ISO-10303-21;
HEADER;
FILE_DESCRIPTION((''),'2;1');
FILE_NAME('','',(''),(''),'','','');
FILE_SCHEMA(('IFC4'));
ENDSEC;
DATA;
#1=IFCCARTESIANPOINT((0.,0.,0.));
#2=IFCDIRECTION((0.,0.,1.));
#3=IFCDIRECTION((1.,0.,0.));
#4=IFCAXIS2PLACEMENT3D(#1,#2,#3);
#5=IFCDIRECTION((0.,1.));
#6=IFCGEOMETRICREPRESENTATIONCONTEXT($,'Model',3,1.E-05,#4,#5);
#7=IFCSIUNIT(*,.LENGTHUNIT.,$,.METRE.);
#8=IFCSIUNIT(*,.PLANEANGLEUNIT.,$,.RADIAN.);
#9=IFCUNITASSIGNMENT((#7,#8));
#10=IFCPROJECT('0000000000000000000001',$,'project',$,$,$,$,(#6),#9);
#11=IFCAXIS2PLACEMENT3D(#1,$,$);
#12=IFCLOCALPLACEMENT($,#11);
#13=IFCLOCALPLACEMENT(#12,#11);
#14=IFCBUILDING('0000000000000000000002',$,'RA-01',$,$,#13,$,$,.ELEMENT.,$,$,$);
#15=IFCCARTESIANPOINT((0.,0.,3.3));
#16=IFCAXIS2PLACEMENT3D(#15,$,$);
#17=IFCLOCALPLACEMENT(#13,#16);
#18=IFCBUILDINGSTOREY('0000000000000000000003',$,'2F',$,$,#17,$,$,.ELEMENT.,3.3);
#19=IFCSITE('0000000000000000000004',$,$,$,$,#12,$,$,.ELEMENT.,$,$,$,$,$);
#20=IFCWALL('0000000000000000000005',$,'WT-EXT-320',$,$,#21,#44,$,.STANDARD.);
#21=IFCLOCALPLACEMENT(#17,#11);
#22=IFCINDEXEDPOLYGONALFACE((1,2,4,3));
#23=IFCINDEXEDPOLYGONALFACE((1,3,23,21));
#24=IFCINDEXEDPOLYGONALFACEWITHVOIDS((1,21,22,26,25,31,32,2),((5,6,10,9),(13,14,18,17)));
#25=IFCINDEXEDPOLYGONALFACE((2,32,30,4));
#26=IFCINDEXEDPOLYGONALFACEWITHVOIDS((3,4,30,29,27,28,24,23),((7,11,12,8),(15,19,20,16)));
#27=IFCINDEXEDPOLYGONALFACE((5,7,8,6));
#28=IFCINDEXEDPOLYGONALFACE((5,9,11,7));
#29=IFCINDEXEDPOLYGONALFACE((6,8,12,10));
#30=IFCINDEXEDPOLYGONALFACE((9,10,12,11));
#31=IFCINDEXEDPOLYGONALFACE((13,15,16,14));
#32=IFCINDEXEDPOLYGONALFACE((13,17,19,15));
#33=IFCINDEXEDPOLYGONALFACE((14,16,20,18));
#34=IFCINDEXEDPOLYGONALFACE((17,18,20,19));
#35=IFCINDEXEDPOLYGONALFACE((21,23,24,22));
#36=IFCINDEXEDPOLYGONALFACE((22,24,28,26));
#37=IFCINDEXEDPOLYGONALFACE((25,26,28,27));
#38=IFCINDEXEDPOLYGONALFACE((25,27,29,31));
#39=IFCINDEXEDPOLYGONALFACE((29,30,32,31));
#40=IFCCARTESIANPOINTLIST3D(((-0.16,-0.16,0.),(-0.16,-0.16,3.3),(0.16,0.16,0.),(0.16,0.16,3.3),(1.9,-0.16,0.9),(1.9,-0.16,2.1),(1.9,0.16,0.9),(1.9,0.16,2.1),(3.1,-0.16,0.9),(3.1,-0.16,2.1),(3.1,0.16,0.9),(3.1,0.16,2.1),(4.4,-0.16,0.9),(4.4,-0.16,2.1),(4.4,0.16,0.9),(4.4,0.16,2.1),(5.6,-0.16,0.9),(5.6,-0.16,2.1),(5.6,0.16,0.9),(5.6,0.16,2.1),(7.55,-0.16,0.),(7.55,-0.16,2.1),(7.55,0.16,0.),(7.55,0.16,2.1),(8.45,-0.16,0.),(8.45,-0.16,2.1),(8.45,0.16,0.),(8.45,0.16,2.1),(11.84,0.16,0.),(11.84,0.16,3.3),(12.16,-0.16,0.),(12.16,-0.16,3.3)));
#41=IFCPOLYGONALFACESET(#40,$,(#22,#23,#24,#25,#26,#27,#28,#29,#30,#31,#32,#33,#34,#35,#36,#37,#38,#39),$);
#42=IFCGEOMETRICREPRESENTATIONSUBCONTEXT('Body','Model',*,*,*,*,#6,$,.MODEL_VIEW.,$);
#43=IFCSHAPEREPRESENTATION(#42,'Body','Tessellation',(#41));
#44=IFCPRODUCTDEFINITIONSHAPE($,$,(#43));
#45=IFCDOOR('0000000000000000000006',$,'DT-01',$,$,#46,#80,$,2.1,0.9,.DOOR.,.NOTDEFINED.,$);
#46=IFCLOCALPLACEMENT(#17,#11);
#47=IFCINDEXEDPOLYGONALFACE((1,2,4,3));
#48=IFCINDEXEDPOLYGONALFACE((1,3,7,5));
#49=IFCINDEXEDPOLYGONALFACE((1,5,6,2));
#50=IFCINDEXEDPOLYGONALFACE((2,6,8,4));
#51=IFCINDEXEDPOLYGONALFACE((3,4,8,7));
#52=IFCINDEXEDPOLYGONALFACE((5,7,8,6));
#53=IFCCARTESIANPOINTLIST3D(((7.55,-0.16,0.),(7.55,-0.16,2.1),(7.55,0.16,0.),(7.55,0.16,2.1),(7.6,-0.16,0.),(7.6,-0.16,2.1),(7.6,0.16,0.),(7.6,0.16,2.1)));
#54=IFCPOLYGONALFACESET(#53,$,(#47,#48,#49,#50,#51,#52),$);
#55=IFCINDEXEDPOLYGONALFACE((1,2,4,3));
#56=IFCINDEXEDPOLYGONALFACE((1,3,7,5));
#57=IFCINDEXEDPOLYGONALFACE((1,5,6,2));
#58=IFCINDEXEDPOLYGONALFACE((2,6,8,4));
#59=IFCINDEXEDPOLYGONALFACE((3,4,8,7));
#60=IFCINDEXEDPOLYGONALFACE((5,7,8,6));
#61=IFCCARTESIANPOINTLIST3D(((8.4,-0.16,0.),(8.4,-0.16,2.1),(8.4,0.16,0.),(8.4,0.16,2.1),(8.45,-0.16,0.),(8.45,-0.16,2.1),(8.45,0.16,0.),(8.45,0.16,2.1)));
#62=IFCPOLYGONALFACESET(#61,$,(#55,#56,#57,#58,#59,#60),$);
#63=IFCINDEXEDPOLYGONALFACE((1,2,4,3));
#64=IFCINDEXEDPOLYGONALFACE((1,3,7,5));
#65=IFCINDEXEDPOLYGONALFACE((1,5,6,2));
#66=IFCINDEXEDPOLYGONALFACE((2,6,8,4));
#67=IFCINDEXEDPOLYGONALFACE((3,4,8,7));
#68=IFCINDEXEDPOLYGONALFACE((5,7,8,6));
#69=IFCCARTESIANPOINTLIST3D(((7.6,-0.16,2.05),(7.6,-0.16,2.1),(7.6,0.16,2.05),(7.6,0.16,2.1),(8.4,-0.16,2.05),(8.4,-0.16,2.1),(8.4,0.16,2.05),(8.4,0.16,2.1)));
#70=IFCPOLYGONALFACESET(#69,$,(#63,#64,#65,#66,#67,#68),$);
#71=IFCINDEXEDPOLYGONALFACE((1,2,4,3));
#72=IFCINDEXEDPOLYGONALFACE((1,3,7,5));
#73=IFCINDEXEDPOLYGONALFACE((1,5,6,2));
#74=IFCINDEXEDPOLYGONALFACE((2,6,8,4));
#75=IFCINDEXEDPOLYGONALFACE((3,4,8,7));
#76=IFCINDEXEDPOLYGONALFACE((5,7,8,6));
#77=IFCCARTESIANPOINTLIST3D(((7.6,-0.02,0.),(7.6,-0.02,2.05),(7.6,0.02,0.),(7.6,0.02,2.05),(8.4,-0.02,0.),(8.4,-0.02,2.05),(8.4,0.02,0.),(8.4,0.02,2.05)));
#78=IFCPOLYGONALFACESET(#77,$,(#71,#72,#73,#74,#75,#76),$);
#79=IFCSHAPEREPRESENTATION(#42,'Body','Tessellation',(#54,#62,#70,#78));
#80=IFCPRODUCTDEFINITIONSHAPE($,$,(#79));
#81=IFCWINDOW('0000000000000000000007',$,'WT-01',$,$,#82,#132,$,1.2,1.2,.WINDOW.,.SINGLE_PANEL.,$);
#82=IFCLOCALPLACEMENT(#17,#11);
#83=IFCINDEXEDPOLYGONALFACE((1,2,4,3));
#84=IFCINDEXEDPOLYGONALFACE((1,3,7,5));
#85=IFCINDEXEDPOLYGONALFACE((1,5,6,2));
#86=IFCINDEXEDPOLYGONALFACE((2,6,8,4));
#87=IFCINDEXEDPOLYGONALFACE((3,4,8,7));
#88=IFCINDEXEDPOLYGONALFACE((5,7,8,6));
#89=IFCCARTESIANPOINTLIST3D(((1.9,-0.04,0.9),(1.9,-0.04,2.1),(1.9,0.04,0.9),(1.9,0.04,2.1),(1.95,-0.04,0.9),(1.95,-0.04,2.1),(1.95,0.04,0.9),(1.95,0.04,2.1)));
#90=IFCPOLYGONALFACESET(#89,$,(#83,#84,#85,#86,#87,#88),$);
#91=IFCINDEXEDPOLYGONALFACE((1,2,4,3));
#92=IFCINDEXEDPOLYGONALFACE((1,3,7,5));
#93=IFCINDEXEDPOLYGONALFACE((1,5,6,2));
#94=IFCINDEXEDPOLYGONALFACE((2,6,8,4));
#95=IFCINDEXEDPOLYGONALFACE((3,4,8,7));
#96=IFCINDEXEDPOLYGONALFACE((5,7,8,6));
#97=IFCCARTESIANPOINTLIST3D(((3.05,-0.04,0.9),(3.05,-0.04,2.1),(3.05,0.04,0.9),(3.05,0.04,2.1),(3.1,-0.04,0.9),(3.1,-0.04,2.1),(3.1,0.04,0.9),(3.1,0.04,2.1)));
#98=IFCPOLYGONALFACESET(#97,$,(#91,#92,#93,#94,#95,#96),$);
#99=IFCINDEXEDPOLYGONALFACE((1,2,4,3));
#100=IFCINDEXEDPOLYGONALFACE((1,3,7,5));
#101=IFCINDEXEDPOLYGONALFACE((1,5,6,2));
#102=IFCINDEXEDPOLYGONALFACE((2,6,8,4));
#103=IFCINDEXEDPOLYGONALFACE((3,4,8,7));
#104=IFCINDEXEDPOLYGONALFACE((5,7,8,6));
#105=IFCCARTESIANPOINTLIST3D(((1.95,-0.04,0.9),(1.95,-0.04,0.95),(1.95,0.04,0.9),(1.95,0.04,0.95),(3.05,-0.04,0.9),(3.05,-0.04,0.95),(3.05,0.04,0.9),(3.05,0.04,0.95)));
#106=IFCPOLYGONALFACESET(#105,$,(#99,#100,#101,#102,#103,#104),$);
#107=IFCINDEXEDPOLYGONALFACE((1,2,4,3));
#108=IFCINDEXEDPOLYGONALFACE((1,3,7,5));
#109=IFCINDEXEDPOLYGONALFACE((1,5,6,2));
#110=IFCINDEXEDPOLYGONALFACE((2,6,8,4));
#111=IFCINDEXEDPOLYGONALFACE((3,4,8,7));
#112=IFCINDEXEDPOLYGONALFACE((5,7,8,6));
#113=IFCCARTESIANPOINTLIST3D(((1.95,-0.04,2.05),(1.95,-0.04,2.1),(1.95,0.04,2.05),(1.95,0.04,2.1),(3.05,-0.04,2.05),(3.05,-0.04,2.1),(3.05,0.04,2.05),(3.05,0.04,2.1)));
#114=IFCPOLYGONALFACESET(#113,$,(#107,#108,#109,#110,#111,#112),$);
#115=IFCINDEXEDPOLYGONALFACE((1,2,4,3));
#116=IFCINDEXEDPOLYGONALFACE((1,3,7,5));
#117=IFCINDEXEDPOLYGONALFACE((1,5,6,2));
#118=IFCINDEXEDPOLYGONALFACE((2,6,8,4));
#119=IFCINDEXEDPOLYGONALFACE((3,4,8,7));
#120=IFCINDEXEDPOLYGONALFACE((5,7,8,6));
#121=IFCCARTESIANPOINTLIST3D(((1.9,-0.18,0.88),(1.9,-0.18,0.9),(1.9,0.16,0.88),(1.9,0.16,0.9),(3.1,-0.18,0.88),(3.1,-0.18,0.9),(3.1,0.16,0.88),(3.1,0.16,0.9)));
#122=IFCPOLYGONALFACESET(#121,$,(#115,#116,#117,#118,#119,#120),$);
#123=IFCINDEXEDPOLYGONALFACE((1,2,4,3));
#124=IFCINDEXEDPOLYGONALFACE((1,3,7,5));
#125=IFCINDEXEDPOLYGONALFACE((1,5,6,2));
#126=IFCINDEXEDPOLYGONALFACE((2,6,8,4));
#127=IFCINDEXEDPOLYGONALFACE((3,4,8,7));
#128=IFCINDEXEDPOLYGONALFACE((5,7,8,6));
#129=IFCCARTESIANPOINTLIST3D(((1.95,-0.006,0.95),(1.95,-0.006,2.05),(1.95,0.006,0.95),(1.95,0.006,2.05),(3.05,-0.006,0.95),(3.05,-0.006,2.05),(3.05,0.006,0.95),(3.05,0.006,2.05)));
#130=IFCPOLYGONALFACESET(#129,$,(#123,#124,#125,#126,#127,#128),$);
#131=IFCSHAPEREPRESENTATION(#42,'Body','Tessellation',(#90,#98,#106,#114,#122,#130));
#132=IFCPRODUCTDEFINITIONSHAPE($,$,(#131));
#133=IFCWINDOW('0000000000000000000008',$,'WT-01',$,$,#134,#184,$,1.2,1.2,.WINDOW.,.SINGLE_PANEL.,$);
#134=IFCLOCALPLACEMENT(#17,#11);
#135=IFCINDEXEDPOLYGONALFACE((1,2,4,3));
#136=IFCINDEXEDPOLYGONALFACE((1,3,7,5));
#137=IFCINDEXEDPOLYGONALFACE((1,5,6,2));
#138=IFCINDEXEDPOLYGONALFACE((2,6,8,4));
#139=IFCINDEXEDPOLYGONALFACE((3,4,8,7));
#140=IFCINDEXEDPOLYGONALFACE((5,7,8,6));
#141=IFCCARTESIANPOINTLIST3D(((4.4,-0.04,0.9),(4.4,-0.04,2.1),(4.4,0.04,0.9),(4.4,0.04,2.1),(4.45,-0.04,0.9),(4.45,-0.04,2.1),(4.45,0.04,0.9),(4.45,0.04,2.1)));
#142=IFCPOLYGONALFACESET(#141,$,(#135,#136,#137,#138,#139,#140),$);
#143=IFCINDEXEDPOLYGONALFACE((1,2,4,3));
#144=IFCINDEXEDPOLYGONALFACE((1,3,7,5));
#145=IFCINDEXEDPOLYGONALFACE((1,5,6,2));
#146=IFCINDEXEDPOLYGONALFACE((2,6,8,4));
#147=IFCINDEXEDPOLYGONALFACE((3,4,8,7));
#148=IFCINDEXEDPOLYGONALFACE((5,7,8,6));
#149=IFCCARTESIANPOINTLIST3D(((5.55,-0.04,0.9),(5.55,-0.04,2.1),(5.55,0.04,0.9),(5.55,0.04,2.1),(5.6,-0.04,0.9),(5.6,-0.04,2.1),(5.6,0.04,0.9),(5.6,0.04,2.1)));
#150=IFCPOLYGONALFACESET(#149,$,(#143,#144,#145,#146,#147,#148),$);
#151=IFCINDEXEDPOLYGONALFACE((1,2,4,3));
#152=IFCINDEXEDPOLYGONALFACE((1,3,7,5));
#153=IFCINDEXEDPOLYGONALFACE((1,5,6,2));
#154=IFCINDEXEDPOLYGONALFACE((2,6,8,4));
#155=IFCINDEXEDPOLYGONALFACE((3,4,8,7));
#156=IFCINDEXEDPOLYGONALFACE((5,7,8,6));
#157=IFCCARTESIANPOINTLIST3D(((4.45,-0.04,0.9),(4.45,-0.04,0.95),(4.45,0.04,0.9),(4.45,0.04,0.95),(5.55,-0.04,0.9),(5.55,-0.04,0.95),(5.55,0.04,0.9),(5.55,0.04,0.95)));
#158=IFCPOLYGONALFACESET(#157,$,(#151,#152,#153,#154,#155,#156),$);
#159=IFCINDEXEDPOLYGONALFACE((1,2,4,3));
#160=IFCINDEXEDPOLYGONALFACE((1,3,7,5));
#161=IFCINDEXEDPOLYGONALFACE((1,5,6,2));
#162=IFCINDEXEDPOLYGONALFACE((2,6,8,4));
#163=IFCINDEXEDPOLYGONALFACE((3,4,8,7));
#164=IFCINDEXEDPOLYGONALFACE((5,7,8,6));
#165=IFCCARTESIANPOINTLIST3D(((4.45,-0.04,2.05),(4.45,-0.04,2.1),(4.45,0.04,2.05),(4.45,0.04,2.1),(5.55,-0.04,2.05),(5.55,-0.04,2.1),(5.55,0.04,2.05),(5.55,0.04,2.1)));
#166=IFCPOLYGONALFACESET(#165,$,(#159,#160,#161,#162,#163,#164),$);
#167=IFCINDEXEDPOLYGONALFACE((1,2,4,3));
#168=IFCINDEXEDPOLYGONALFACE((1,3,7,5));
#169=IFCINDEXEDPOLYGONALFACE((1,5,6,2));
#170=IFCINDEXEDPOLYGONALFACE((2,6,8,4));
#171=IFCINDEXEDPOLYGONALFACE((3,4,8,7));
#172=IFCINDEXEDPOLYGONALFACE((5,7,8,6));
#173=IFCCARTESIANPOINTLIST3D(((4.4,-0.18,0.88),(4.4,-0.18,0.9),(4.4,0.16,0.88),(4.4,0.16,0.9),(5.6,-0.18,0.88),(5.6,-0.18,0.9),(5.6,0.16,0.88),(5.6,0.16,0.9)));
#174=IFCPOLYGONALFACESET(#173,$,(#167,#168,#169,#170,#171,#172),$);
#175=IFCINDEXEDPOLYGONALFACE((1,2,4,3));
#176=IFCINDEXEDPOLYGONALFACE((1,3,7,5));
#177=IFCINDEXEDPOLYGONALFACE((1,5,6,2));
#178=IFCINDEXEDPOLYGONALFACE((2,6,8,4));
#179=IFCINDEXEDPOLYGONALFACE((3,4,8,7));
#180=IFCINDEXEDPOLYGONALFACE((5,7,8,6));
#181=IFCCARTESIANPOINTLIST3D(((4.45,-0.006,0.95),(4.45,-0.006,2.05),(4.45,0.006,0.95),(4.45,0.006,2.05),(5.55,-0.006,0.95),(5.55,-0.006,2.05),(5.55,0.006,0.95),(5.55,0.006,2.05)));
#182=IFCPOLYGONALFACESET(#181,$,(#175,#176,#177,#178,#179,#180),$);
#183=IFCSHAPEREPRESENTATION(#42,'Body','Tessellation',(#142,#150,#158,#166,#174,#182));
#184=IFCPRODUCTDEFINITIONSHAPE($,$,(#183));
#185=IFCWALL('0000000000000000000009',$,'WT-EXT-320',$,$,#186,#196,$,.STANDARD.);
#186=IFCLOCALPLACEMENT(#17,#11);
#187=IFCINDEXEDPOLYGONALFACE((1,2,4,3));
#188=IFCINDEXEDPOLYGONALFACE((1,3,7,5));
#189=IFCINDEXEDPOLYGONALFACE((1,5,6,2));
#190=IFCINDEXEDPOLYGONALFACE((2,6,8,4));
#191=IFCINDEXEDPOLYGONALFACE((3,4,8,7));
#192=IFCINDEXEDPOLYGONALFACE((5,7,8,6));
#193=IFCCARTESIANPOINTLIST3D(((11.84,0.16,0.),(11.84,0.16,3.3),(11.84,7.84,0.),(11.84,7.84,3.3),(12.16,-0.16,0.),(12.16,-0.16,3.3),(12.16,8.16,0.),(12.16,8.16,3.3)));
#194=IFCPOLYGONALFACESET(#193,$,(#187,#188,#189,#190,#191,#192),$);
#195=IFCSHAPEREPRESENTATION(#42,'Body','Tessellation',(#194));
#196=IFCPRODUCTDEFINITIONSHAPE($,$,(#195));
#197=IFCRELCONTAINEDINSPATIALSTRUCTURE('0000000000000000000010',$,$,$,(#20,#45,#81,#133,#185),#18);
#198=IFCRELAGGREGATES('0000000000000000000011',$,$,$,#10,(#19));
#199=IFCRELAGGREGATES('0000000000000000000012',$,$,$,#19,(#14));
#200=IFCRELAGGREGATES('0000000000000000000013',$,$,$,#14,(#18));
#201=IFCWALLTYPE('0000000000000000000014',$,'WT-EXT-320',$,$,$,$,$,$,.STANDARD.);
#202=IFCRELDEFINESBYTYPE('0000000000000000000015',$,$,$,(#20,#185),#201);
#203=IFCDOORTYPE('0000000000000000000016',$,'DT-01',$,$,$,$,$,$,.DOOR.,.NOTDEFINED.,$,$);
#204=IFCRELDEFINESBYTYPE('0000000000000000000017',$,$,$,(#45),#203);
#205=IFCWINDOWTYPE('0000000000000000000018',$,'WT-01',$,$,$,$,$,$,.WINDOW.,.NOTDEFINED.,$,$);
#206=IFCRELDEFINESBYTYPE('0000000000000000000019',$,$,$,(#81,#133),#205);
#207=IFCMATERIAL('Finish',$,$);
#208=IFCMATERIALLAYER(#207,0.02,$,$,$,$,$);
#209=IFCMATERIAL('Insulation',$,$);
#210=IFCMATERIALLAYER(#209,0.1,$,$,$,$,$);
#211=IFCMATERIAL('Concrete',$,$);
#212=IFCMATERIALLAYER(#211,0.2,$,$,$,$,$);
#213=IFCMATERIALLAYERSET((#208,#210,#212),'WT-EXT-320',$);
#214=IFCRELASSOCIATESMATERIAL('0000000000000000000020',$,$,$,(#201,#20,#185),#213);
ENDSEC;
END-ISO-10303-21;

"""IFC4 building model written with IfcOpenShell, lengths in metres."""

from ifc_helpers import new_model, si_unit, direction, frame, frame_2d, origin, origin_with_axes, place, context, subcontext, project, spatial, polyline, rectangle, outline, extrude, material, layer, layer_set, layer_usage, type_object, element, fill, save


model = new_model("IFC4")

# Units and contexts
model_context = context("Model", 3, precision=1e-05, world=origin_with_axes(), true_north=direction((0.0, 1.0)))
body_context = subcontext(model_context, "Body", "Model", "MODEL_VIEW")
ifc_project = project(units=[si_unit("LENGTHUNIT", "METRE"), si_unit("PLANEANGLEUNIT", "RADIAN")], contexts=[model_context])

# Site, building, storey
site_placement = place(None, origin())
site = spatial("IfcSite", under=ifc_project, at=site_placement, CompositionType="ELEMENT")
building_placement = place(site_placement, origin())
building = spatial("IfcBuilding", under=site, at=building_placement, Name="RA-01", CompositionType="ELEMENT")
storey_placement = place(building_placement, frame((0.0, 0.0, 3.3)))
storey = spatial("IfcBuildingStorey", under=building, at=storey_placement, Name="2F", CompositionType="ELEMENT", Elevation=3.3)

# Shared definitions
ifc_material_1 = material(Name="Concrete")

# Wall, openings, door, windows
ifc_material_2 = material(Name="Finish")
ifc_layer_1 = layer(ifc_material_2, 0.02)
ifc_material_3 = material(Name="Insulation")
ifc_layer_2 = layer(ifc_material_3, 0.1)
ifc_layer_3 = layer(ifc_material_1, 0.2)
ifc_layer_set_1 = layer_set([ifc_layer_1, ifc_layer_2, ifc_layer_3], Name="WT-EXT-320")
ifc_layer_usage_1 = layer_usage(ifc_layer_set_1, "AXIS2", "NEGATIVE", 0.16)
wall_type_1 = type_object("IfcWallType", Name="WT-EXT-320", PredefinedType="STANDARD", material=ifc_layer_set_1)
wall_1_placement = place(storey_placement, origin())
wall_1 = element("IfcWall", 1, at=wall_1_placement, inside=storey, type_object=wall_type_1, material=ifc_layer_usage_1, Name="WT-EXT-320", PredefinedType="STANDARD", context=body_context, shape_type="SweptSolid", body=[
    extrude(outline(polyline([(-0.16, -0.16), (12.16, -0.16), (11.84, 0.16), (0.16, 0.16), (-0.16, -0.16)])), origin(), (0.0, 0.0, 1.0), 3.3),
])
opening_1_placement = place(wall_1_placement, frame((7.55, 0.0, 0.0)))
opening_1 = element("IfcOpeningElement", 2, at=opening_1_placement, cuts=wall_1, PredefinedType="OPENING", context=body_context, shape_type="SweptSolid", body=[
    extrude(rectangle(XDim=0.9, YDim=0.42, at=frame_2d((0.45, 0.0))), origin(), (0.0, 0.0, 1.0), 2.1),
])
opening_2_placement = place(wall_1_placement, frame((1.9, 0.0, 0.9)))
opening_2 = element("IfcOpeningElement", 3, at=opening_2_placement, cuts=wall_1, PredefinedType="OPENING", context=body_context, shape_type="SweptSolid", body=[
    extrude(rectangle(XDim=1.2, YDim=0.42, at=frame_2d((0.6, 0.0))), origin(), (0.0, 0.0, 1.0), 1.2),
])
opening_3_placement = place(wall_1_placement, frame((4.4, 0.0, 0.9)))
opening_3 = element("IfcOpeningElement", 4, at=opening_3_placement, cuts=wall_1, PredefinedType="OPENING", context=body_context, shape_type="SweptSolid", body=[
    extrude(rectangle(XDim=1.2, YDim=0.42, at=frame_2d((0.6, 0.0))), origin(), (0.0, 0.0, 1.0), 1.2),
])
door_type_1 = type_object("IfcDoorType", Name="DT-01", OperationType="NOTDEFINED", PredefinedType="DOOR")
door_1_placement = place(opening_1_placement, origin())
door_1 = element("IfcDoor", 5, at=door_1_placement, inside=storey, type_object=door_type_1, Name="DT-01", OperationType="NOTDEFINED", OverallHeight=2.1, OverallWidth=0.9, PredefinedType="DOOR", context=body_context, shape_type="SweptSolid", body=[
    extrude(outline(polyline([(0.0, -0.16), (0.05, -0.16), (0.05, 0.16), (0.0, 0.16), (0.0, -0.16)])), origin(), (0.0, 0.0, 1.0), 2.1),
    extrude(outline(polyline([(0.85, -0.16), (0.9, -0.16), (0.9, 0.16), (0.85, 0.16), (0.85, -0.16)])), origin(), (0.0, 0.0, 1.0), 2.1),
    extrude(outline(polyline([(0.05, -0.16), (0.85, -0.16), (0.85, 0.16), (0.05, 0.16), (0.05, -0.16)])), frame((0.0, 0.0, 2.05)), (0.0, 0.0, 1.0), 0.05),
    extrude(outline(polyline([(0.05, -0.02), (0.85, -0.02), (0.85, 0.02), (0.05, 0.02), (0.05, -0.02)])), origin(), (0.0, 0.0, 1.0), 2.05),
])
fill(opening_1, door_1)
window_type_1 = type_object("IfcWindowType", Name="WT-01", PartitioningType="NOTDEFINED", PredefinedType="WINDOW")
window_1_placement = place(opening_2_placement, origin())
window_1 = element("IfcWindow", 6, at=window_1_placement, inside=storey, type_object=window_type_1, Name="WT-01", OverallHeight=1.2, OverallWidth=1.2, PartitioningType="SINGLE_PANEL", PredefinedType="WINDOW", context=body_context, shape_type="SweptSolid", body=[
    extrude(outline(polyline([(0.0, -0.04), (0.05, -0.04), (0.05, 0.04), (0.0, 0.04), (0.0, -0.04)])), origin(), (0.0, 0.0, 1.0), 1.2),
    extrude(outline(polyline([(1.15, -0.04), (1.2, -0.04), (1.2, 0.04), (1.15, 0.04), (1.15, -0.04)])), origin(), (0.0, 0.0, 1.0), 1.2),
    extrude(outline(polyline([(0.05, -0.04), (1.15, -0.04), (1.15, 0.04), (0.05, 0.04), (0.05, -0.04)])), origin(), (0.0, 0.0, 1.0), 0.05),
    extrude(outline(polyline([(0.05, -0.04), (1.15, -0.04), (1.15, 0.04), (0.05, 0.04), (0.05, -0.04)])), frame((0.0, 0.0, 1.15)), (0.0, 0.0, 1.0), 0.05),
    extrude(outline(polyline([(0.0, -0.18), (1.2, -0.18), (1.2, 0.16), (0.0, 0.16), (0.0, -0.18)])), frame((0.0, 0.0, -0.02)), (0.0, 0.0, 1.0), 0.02),
    extrude(outline(polyline([(0.05, -0.006), (1.15, -0.006), (1.15, 0.006), (0.05, 0.006), (0.05, -0.006)])), frame((0.0, 0.0, 0.05)), (0.0, 0.0, 1.0), 1.1),
])
fill(opening_2, window_1)
window_2_placement = place(opening_3_placement, origin())
window_2 = element("IfcWindow", 7, at=window_2_placement, inside=storey, type_object=window_type_1, Name="WT-01", OverallHeight=1.2, OverallWidth=1.2, PartitioningType="SINGLE_PANEL", PredefinedType="WINDOW", context=body_context, shape_type="SweptSolid", body=[
    extrude(outline(polyline([(0.0, -0.04), (0.05, -0.04), (0.05, 0.04), (0.0, 0.04), (0.0, -0.04)])), origin(), (0.0, 0.0, 1.0), 1.2),
    extrude(outline(polyline([(1.15, -0.04), (1.2, -0.04), (1.2, 0.04), (1.15, 0.04), (1.15, -0.04)])), origin(), (0.0, 0.0, 1.0), 1.2),
    extrude(outline(polyline([(0.05, -0.04), (1.15, -0.04), (1.15, 0.04), (0.05, 0.04), (0.05, -0.04)])), origin(), (0.0, 0.0, 1.0), 0.05),
    extrude(outline(polyline([(0.05, -0.04), (1.15, -0.04), (1.15, 0.04), (0.05, 0.04), (0.05, -0.04)])), frame((0.0, 0.0, 1.15)), (0.0, 0.0, 1.0), 0.05),
    extrude(outline(polyline([(0.0, -0.18), (1.2, -0.18), (1.2, 0.16), (0.0, 0.16), (0.0, -0.18)])), frame((0.0, 0.0, -0.02)), (0.0, 0.0, 1.0), 0.02),
    extrude(outline(polyline([(0.05, -0.006), (1.15, -0.006), (1.15, 0.006), (0.05, 0.006), (0.05, -0.006)])), frame((0.0, 0.0, 0.05)), (0.0, 0.0, 1.0), 1.1),
])
fill(opening_3, window_2)

# Wall
wall_2_placement = place(storey_placement, frame((12.0, 0.0, 0.0), z_axis=(0.0, 0.0, 1.0), x_axis=(0.0, 1.0, 0.0)))
element("IfcWall", 8, at=wall_2_placement, inside=storey, type_object=wall_type_1, material=ifc_layer_usage_1, Name="WT-EXT-320", PredefinedType="STANDARD", context=body_context, shape_type="SweptSolid", body=[
    extrude(outline(polyline([(-0.16, -0.16), (8.16, -0.16), (7.84, 0.16), (0.16, 0.16), (-0.16, -0.16)])), origin(), (0.0, 0.0, 1.0), 3.3),
])

save(model, "model.ifc")
